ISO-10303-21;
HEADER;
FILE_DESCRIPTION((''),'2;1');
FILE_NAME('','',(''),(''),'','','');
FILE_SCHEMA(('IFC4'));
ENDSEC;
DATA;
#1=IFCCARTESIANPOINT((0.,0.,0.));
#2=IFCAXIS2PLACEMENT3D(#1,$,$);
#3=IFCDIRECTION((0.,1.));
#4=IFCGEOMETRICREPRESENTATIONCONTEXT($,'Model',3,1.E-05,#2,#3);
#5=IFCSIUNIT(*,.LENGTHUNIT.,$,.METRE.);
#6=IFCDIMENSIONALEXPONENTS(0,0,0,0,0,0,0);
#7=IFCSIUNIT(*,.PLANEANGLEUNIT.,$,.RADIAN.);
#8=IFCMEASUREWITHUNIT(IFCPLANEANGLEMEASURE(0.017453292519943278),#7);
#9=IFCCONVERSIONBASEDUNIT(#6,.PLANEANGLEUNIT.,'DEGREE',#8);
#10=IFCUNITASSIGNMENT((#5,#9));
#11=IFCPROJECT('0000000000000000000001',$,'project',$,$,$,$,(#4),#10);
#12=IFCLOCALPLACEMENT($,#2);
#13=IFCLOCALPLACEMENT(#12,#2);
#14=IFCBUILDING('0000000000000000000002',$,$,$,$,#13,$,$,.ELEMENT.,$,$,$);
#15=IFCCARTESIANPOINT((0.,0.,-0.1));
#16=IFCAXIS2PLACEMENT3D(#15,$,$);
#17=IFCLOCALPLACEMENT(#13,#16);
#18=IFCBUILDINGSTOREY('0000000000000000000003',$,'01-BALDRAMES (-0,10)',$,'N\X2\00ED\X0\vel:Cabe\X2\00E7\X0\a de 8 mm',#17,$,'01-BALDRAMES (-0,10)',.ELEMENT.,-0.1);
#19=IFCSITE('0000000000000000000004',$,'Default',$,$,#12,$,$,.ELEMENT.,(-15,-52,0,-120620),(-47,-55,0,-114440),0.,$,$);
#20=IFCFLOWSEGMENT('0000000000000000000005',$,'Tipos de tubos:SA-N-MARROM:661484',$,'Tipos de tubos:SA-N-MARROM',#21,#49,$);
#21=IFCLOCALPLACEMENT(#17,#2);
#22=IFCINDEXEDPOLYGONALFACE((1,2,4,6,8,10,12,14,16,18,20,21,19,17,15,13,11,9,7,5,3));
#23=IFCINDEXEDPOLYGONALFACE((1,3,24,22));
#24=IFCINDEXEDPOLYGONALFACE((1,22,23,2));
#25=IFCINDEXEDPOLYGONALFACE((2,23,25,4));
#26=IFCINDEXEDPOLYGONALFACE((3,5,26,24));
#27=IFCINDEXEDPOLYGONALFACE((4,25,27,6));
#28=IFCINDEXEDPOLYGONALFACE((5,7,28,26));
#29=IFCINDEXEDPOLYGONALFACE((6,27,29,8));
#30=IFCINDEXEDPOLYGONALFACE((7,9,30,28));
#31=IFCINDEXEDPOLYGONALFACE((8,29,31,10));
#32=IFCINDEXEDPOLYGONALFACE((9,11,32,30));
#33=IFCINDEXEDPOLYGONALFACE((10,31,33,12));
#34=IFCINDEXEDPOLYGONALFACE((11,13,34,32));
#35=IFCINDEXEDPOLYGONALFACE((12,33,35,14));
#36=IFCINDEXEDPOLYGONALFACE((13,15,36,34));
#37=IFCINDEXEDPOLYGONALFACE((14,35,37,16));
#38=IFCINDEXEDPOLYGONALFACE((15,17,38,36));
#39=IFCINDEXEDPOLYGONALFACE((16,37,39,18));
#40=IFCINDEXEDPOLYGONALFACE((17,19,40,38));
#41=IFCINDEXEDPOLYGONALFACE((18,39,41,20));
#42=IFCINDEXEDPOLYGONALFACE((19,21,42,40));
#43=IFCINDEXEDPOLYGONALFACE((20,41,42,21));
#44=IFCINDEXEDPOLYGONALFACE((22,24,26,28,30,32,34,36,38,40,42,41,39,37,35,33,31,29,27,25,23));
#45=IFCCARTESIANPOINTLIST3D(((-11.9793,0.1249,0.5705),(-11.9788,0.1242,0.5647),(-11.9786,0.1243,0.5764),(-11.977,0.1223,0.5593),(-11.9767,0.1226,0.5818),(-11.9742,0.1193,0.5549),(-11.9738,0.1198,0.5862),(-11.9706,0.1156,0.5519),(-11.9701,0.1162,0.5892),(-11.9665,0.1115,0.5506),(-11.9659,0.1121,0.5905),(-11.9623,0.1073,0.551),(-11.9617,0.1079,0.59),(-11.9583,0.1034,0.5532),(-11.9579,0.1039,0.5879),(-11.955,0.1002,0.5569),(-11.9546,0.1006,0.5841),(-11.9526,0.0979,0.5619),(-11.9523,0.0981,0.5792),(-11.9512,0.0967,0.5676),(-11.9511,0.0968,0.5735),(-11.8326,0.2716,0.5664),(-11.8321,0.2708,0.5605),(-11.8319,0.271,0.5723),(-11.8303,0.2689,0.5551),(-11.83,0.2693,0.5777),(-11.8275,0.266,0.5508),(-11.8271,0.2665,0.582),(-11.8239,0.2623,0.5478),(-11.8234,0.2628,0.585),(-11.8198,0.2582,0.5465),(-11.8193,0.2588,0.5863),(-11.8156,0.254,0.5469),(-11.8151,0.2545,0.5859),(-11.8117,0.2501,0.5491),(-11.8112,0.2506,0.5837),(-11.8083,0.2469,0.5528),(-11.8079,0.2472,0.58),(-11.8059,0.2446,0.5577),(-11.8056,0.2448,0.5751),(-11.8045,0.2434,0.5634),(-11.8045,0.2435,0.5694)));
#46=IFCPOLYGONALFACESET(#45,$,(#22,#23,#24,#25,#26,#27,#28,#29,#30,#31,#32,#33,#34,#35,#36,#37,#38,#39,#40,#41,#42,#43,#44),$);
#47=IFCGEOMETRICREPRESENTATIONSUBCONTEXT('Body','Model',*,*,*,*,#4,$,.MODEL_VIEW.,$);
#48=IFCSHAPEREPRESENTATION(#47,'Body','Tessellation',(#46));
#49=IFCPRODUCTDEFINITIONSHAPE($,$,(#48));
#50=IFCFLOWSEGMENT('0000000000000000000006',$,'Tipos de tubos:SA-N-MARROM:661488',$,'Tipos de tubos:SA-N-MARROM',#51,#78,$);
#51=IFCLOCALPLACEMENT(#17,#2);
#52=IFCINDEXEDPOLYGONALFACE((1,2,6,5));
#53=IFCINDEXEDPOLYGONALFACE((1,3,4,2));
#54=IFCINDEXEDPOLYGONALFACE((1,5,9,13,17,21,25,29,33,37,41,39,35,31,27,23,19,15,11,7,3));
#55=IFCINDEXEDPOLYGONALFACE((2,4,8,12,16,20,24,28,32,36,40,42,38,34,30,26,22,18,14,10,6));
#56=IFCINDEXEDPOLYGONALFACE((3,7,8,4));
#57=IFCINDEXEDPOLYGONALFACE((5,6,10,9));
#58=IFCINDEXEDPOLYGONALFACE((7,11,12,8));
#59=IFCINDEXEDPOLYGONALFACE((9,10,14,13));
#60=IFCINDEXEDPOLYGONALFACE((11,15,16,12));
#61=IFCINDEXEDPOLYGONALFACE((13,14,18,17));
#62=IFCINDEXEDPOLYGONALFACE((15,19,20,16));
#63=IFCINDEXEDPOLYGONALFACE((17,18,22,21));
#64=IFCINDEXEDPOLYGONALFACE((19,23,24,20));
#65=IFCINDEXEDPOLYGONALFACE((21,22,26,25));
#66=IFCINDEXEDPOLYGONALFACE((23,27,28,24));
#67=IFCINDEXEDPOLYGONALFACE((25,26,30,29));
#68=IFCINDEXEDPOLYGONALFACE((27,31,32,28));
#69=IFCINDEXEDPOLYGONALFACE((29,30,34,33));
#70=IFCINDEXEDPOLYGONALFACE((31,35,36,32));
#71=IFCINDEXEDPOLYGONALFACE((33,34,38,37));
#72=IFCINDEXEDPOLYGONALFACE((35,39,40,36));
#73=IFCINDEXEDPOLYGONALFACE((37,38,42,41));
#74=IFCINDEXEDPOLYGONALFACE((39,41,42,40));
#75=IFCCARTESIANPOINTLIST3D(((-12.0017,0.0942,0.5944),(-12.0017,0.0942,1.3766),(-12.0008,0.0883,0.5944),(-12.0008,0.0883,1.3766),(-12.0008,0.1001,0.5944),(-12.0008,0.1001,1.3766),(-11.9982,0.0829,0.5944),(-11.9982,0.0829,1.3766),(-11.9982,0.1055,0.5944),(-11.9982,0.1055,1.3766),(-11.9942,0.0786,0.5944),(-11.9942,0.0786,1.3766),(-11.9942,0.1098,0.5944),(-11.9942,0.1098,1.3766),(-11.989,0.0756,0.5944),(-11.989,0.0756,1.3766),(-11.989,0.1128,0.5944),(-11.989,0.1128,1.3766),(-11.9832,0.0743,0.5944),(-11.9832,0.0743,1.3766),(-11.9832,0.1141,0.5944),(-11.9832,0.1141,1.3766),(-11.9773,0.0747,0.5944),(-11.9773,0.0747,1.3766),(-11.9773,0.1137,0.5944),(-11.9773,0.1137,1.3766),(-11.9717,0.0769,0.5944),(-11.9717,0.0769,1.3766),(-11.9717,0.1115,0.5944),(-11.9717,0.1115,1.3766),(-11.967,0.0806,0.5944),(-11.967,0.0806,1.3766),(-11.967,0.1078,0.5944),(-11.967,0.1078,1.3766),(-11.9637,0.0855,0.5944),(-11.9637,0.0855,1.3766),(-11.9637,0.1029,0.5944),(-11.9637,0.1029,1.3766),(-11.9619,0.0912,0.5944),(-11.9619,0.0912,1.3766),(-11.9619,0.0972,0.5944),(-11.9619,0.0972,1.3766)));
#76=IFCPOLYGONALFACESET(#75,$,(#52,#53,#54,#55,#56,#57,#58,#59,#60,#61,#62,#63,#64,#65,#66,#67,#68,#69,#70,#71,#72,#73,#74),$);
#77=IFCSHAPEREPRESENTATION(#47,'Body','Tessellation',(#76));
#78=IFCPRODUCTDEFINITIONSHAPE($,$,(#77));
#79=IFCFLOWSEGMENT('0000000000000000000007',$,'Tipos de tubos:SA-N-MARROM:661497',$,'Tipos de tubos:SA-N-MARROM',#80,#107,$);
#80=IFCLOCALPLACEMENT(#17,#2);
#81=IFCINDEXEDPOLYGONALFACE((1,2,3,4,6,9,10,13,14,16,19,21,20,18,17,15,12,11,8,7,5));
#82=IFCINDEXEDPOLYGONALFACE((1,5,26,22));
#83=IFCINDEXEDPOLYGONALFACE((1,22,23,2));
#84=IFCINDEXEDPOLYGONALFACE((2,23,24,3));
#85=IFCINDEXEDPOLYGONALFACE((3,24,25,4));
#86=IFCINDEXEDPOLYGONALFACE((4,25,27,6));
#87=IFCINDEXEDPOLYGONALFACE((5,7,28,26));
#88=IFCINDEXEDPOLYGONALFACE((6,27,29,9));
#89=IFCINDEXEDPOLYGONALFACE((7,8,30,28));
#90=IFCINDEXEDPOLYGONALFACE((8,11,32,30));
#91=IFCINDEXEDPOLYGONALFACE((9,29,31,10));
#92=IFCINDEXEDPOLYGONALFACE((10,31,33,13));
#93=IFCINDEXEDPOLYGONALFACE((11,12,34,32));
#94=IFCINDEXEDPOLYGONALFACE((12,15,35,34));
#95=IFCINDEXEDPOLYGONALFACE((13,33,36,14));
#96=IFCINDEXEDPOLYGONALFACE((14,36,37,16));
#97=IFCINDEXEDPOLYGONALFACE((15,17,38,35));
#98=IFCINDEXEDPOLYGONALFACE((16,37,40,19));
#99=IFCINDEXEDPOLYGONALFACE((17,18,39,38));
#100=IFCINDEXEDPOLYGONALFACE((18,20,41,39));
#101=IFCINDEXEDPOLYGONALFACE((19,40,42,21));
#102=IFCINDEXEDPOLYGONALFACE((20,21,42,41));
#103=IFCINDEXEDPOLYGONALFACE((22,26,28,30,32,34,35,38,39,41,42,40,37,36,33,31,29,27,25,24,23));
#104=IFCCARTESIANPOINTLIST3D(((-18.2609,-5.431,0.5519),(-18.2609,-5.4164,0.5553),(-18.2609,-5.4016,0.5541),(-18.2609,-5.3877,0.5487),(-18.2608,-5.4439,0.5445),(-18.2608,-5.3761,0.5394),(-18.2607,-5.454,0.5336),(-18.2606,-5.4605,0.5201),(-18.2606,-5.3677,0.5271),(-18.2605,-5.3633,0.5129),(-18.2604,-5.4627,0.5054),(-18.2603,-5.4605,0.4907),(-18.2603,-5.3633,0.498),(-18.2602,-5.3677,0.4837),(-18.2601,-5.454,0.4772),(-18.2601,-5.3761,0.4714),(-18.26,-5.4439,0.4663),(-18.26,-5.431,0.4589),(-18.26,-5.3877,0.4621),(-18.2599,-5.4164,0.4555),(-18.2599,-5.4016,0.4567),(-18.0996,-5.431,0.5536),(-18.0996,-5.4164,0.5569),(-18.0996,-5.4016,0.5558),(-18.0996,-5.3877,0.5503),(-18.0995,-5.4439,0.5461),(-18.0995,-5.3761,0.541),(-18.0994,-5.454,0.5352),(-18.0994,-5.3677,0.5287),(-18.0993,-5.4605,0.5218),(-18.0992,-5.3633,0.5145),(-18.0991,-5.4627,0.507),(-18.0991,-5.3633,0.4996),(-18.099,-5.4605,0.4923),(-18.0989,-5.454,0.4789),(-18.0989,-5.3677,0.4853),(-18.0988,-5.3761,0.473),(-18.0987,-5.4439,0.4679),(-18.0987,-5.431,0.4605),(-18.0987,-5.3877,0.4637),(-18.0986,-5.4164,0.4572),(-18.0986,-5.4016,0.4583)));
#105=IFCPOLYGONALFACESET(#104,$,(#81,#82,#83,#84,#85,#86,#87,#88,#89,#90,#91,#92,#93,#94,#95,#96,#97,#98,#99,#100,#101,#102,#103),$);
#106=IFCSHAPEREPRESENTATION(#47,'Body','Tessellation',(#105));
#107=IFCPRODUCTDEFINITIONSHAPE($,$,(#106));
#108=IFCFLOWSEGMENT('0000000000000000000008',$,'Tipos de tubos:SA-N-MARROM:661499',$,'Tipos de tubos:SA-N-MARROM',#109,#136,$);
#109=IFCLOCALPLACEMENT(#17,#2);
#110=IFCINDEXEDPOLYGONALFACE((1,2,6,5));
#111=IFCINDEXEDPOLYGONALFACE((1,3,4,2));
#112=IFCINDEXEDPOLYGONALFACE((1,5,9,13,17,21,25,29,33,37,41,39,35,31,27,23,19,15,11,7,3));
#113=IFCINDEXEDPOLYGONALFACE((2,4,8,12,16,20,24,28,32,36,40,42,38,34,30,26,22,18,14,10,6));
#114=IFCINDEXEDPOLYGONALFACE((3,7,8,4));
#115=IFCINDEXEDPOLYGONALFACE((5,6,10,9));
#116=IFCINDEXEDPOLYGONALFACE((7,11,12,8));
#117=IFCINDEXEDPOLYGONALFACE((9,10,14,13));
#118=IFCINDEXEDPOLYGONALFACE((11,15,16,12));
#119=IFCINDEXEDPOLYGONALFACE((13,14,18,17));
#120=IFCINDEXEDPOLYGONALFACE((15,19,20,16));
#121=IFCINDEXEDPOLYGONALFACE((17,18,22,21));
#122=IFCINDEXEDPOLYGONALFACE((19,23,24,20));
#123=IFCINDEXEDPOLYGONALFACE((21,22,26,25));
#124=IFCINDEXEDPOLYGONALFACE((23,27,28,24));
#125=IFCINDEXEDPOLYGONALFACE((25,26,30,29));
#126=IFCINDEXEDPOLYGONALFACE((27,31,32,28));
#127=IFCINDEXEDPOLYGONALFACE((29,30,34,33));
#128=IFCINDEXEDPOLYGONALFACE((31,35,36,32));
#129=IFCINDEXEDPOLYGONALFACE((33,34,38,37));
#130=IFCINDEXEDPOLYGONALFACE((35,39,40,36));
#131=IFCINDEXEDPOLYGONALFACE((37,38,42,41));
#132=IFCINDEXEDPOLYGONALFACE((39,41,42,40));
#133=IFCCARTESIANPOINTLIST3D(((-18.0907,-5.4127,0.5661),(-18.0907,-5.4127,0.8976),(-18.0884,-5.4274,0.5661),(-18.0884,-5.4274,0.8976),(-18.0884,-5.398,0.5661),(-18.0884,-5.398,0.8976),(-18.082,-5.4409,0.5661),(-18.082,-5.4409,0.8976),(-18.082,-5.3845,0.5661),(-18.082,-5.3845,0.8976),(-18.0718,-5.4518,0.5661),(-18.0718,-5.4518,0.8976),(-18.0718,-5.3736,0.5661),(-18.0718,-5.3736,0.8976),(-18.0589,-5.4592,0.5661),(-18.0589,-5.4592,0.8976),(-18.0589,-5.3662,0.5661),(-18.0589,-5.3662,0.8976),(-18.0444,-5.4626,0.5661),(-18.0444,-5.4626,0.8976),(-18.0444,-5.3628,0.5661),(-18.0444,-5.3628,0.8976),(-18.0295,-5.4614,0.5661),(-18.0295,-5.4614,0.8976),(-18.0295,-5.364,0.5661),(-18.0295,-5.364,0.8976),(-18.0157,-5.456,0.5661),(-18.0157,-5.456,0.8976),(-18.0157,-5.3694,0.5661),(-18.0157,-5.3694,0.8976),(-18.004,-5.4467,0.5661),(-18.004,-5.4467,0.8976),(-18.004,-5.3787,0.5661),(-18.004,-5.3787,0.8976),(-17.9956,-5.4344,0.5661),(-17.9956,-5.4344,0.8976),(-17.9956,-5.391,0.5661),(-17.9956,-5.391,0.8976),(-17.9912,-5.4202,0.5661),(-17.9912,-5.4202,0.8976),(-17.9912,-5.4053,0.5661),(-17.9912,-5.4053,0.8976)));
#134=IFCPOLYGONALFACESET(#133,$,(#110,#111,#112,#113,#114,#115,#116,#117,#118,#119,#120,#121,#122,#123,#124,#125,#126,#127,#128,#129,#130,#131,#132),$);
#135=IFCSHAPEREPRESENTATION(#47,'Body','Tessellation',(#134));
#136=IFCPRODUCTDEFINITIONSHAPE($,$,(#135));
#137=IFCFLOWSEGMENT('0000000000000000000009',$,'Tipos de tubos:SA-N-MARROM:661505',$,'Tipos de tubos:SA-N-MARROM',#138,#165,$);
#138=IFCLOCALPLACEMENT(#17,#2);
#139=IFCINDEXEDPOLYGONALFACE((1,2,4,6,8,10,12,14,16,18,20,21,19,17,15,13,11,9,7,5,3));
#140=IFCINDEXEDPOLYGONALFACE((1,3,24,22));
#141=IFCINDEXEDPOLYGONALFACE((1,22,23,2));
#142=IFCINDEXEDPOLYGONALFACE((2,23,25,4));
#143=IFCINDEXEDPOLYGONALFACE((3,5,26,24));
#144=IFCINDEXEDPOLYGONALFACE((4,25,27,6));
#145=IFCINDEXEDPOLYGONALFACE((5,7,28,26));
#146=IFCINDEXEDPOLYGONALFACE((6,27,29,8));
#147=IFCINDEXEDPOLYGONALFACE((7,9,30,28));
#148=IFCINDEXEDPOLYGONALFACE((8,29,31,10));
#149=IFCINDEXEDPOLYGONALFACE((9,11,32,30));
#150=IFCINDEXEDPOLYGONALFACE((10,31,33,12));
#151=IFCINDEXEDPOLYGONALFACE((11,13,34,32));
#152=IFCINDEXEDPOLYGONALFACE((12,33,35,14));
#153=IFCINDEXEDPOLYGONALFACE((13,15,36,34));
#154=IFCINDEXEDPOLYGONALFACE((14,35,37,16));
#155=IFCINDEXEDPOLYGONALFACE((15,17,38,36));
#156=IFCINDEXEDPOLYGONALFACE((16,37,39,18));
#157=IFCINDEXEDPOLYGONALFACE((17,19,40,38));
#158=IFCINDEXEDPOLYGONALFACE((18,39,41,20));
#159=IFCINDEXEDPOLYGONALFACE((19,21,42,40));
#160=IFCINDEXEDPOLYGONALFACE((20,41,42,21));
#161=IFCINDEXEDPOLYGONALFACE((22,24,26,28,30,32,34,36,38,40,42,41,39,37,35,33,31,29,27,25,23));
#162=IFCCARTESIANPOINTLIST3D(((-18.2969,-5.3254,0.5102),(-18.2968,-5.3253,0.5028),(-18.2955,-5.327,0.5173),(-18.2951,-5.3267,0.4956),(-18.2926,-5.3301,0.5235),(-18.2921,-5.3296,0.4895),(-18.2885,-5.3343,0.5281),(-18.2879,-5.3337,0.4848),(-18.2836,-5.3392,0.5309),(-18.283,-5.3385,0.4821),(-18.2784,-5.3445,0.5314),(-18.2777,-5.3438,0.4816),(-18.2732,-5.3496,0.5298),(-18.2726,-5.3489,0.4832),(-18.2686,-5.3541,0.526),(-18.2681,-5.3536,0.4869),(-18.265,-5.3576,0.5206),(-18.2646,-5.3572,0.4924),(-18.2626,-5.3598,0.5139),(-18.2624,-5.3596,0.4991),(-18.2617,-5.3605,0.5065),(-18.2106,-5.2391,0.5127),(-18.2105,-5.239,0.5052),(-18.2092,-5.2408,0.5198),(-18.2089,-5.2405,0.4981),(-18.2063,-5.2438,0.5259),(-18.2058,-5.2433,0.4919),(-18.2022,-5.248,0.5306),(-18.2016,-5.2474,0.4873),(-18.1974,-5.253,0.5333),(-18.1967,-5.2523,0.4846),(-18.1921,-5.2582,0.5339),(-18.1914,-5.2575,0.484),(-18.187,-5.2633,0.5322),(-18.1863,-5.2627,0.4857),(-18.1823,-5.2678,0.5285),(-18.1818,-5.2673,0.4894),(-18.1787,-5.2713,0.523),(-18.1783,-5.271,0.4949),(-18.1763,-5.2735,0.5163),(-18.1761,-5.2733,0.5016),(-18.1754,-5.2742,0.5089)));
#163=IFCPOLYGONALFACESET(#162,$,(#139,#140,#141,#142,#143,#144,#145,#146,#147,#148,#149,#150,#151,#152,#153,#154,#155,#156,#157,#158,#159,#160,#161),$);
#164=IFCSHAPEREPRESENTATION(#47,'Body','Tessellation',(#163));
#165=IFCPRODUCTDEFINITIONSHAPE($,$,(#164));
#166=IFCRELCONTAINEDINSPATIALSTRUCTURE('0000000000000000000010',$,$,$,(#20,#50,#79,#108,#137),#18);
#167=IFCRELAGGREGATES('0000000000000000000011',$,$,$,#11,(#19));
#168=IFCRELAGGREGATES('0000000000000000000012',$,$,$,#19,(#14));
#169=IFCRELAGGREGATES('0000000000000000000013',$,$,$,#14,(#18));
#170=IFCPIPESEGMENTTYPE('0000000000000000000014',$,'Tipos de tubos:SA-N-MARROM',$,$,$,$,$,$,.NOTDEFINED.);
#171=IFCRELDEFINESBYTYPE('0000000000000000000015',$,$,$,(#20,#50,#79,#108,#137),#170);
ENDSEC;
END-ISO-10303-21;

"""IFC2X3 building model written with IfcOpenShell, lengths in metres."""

from ifc_helpers import new_model, entity, si_unit, converted_unit, direction, frame, frame_2d, origin, origin_2d_with_axis, place, context, subcontext, project, spatial, circle, extrude, type_object, element, save


model = new_model("IFC2X3")

# Units and contexts
model_context = context("Model", 3, precision=1e-05, world=origin(), true_north=direction((0.0, 1.0)))
body_context = subcontext(model_context, "Body", "Model", "MODEL_VIEW")
ifc_project = project(units=[si_unit("LENGTHUNIT", "METRE"), converted_unit("PLANEANGLEUNIT", "DEGREE", entity("IfcPlaneAngleMeasure", 0.017453292519943278), si_unit("PLANEANGLEUNIT", "RADIAN"), dimensions=[0, 0, 0, 0, 0, 0, 0])], contexts=[model_context])

# Site, building, storey
site_placement = place(None, origin())
site = spatial("IfcSite", under=ifc_project, at=site_placement, Name="Default", CompositionType="ELEMENT", RefLatitude=(-15, -52, 0, -120620), RefLongitude=(-47, -55, 0, -114440), RefElevation=0.0)
building_placement = place(site_placement, origin())
building = spatial("IfcBuilding", under=site, at=building_placement, CompositionType="ELEMENT")
storey_placement = place(building_placement, frame((0.0, 0.0, -0.1)))
storey = spatial("IfcBuildingStorey", under=building, at=storey_placement, Name="01-BALDRAMES (-0,10)", ObjectType="Nível:Cabeça de 8 mm", LongName="01-BALDRAMES (-0,10)", CompositionType="ELEMENT", Elevation=-0.1)

# Flow segments
pipe_segment_type_1 = type_object("IfcPipeSegmentType", Name="Tipos de tubos:SA-N-MARROM", PredefinedType="NOTDEFINED")
flow_segment_1_placement = place(storey_placement, origin())
element("IfcFlowSegment", 1, at=flow_segment_1_placement, inside=storey, type_object=pipe_segment_type_1, Name="Tipos de tubos:SA-N-MARROM:661484", ObjectType="Tipos de tubos:SA-N-MARROM", context=body_context, shape_type="SweptSolid", body=[
    extrude(circle(Radius=0.02, at=frame_2d((0.0, 0.0), x_axis=(1.0, 0.0))), frame((-11.9652, 0.1107, 0.5705), z_axis=(0.706965, 0.706966, -0.019996), x_axis=(-0.707107, 0.707106, 0.0)), (0.0, 0.0, 1.0), 0.2075),
])
flow_segment_2_placement = place(storey_placement, origin())
element("IfcFlowSegment", 2, at=flow_segment_2_placement, inside=storey, type_object=pipe_segment_type_1, Name="Tipos de tubos:SA-N-MARROM:661488", ObjectType="Tipos de tubos:SA-N-MARROM", context=body_context, shape_type="SweptSolid", body=[
    extrude(circle(Radius=0.02, at=frame_2d((0.0, 0.0), x_axis=(1.0, 0.0))), frame((-11.9817, 0.0942, 0.5944), z_axis=(0.0, 0.0, 1.0), x_axis=(-1.0, 0.0, 0.0)), (0.0, 0.0, 1.0), 0.7822),
])
flow_segment_3_placement = place(storey_placement, origin())
element("IfcFlowSegment", 3, at=flow_segment_3_placement, inside=storey, type_object=pipe_segment_type_1, Name="Tipos de tubos:SA-N-MARROM:661497", ObjectType="Tipos de tubos:SA-N-MARROM", context=body_context, shape_type="SweptSolid", body=[
    extrude(circle(Radius=0.05, at=frame_2d((0.0, 0.0), x_axis=(1.0, 0.0))), frame((-18.2604, -5.4127, 0.5054), z_axis=(0.99995, 0.000001, 0.01), x_axis=(0.000001, -1.0, 0.0)), (0.0, 0.0, 1.0), 0.1613),
])
flow_segment_4_placement = place(storey_placement, origin())
element("IfcFlowSegment", 4, at=flow_segment_4_placement, inside=storey, type_object=pipe_segment_type_1, Name="Tipos de tubos:SA-N-MARROM:661499", ObjectType="Tipos de tubos:SA-N-MARROM", context=body_context, shape_type="SweptSolid", body=[
    extrude(circle(Radius=0.05, at=origin_2d_with_axis()), frame((-18.0407, -5.4127, 0.5661), z_axis=(0.0, 0.0, 1.0), x_axis=(-1.0, 0.0, 0.0)), (0.0, 0.0, 1.0), 0.3315),
])
flow_segment_5_placement = place(storey_placement, origin())
element("IfcFlowSegment", 5, at=flow_segment_5_placement, inside=storey, type_object=pipe_segment_type_1, Name="Tipos de tubos:SA-N-MARROM:661505", ObjectType="Tipos de tubos:SA-N-MARROM", context=body_context, shape_type="SweptSolid", body=[
    extrude(circle(Radius=0.025, at=origin_2d_with_axis()), frame((-18.2794, -5.3428, 0.5065), z_axis=(0.706965, 0.706966, 0.019996), x_axis=(0.707107, -0.707106, 0.0)), (0.0, 0.0, 1.0), 0.122),
])

save(model, "model.ifc")
